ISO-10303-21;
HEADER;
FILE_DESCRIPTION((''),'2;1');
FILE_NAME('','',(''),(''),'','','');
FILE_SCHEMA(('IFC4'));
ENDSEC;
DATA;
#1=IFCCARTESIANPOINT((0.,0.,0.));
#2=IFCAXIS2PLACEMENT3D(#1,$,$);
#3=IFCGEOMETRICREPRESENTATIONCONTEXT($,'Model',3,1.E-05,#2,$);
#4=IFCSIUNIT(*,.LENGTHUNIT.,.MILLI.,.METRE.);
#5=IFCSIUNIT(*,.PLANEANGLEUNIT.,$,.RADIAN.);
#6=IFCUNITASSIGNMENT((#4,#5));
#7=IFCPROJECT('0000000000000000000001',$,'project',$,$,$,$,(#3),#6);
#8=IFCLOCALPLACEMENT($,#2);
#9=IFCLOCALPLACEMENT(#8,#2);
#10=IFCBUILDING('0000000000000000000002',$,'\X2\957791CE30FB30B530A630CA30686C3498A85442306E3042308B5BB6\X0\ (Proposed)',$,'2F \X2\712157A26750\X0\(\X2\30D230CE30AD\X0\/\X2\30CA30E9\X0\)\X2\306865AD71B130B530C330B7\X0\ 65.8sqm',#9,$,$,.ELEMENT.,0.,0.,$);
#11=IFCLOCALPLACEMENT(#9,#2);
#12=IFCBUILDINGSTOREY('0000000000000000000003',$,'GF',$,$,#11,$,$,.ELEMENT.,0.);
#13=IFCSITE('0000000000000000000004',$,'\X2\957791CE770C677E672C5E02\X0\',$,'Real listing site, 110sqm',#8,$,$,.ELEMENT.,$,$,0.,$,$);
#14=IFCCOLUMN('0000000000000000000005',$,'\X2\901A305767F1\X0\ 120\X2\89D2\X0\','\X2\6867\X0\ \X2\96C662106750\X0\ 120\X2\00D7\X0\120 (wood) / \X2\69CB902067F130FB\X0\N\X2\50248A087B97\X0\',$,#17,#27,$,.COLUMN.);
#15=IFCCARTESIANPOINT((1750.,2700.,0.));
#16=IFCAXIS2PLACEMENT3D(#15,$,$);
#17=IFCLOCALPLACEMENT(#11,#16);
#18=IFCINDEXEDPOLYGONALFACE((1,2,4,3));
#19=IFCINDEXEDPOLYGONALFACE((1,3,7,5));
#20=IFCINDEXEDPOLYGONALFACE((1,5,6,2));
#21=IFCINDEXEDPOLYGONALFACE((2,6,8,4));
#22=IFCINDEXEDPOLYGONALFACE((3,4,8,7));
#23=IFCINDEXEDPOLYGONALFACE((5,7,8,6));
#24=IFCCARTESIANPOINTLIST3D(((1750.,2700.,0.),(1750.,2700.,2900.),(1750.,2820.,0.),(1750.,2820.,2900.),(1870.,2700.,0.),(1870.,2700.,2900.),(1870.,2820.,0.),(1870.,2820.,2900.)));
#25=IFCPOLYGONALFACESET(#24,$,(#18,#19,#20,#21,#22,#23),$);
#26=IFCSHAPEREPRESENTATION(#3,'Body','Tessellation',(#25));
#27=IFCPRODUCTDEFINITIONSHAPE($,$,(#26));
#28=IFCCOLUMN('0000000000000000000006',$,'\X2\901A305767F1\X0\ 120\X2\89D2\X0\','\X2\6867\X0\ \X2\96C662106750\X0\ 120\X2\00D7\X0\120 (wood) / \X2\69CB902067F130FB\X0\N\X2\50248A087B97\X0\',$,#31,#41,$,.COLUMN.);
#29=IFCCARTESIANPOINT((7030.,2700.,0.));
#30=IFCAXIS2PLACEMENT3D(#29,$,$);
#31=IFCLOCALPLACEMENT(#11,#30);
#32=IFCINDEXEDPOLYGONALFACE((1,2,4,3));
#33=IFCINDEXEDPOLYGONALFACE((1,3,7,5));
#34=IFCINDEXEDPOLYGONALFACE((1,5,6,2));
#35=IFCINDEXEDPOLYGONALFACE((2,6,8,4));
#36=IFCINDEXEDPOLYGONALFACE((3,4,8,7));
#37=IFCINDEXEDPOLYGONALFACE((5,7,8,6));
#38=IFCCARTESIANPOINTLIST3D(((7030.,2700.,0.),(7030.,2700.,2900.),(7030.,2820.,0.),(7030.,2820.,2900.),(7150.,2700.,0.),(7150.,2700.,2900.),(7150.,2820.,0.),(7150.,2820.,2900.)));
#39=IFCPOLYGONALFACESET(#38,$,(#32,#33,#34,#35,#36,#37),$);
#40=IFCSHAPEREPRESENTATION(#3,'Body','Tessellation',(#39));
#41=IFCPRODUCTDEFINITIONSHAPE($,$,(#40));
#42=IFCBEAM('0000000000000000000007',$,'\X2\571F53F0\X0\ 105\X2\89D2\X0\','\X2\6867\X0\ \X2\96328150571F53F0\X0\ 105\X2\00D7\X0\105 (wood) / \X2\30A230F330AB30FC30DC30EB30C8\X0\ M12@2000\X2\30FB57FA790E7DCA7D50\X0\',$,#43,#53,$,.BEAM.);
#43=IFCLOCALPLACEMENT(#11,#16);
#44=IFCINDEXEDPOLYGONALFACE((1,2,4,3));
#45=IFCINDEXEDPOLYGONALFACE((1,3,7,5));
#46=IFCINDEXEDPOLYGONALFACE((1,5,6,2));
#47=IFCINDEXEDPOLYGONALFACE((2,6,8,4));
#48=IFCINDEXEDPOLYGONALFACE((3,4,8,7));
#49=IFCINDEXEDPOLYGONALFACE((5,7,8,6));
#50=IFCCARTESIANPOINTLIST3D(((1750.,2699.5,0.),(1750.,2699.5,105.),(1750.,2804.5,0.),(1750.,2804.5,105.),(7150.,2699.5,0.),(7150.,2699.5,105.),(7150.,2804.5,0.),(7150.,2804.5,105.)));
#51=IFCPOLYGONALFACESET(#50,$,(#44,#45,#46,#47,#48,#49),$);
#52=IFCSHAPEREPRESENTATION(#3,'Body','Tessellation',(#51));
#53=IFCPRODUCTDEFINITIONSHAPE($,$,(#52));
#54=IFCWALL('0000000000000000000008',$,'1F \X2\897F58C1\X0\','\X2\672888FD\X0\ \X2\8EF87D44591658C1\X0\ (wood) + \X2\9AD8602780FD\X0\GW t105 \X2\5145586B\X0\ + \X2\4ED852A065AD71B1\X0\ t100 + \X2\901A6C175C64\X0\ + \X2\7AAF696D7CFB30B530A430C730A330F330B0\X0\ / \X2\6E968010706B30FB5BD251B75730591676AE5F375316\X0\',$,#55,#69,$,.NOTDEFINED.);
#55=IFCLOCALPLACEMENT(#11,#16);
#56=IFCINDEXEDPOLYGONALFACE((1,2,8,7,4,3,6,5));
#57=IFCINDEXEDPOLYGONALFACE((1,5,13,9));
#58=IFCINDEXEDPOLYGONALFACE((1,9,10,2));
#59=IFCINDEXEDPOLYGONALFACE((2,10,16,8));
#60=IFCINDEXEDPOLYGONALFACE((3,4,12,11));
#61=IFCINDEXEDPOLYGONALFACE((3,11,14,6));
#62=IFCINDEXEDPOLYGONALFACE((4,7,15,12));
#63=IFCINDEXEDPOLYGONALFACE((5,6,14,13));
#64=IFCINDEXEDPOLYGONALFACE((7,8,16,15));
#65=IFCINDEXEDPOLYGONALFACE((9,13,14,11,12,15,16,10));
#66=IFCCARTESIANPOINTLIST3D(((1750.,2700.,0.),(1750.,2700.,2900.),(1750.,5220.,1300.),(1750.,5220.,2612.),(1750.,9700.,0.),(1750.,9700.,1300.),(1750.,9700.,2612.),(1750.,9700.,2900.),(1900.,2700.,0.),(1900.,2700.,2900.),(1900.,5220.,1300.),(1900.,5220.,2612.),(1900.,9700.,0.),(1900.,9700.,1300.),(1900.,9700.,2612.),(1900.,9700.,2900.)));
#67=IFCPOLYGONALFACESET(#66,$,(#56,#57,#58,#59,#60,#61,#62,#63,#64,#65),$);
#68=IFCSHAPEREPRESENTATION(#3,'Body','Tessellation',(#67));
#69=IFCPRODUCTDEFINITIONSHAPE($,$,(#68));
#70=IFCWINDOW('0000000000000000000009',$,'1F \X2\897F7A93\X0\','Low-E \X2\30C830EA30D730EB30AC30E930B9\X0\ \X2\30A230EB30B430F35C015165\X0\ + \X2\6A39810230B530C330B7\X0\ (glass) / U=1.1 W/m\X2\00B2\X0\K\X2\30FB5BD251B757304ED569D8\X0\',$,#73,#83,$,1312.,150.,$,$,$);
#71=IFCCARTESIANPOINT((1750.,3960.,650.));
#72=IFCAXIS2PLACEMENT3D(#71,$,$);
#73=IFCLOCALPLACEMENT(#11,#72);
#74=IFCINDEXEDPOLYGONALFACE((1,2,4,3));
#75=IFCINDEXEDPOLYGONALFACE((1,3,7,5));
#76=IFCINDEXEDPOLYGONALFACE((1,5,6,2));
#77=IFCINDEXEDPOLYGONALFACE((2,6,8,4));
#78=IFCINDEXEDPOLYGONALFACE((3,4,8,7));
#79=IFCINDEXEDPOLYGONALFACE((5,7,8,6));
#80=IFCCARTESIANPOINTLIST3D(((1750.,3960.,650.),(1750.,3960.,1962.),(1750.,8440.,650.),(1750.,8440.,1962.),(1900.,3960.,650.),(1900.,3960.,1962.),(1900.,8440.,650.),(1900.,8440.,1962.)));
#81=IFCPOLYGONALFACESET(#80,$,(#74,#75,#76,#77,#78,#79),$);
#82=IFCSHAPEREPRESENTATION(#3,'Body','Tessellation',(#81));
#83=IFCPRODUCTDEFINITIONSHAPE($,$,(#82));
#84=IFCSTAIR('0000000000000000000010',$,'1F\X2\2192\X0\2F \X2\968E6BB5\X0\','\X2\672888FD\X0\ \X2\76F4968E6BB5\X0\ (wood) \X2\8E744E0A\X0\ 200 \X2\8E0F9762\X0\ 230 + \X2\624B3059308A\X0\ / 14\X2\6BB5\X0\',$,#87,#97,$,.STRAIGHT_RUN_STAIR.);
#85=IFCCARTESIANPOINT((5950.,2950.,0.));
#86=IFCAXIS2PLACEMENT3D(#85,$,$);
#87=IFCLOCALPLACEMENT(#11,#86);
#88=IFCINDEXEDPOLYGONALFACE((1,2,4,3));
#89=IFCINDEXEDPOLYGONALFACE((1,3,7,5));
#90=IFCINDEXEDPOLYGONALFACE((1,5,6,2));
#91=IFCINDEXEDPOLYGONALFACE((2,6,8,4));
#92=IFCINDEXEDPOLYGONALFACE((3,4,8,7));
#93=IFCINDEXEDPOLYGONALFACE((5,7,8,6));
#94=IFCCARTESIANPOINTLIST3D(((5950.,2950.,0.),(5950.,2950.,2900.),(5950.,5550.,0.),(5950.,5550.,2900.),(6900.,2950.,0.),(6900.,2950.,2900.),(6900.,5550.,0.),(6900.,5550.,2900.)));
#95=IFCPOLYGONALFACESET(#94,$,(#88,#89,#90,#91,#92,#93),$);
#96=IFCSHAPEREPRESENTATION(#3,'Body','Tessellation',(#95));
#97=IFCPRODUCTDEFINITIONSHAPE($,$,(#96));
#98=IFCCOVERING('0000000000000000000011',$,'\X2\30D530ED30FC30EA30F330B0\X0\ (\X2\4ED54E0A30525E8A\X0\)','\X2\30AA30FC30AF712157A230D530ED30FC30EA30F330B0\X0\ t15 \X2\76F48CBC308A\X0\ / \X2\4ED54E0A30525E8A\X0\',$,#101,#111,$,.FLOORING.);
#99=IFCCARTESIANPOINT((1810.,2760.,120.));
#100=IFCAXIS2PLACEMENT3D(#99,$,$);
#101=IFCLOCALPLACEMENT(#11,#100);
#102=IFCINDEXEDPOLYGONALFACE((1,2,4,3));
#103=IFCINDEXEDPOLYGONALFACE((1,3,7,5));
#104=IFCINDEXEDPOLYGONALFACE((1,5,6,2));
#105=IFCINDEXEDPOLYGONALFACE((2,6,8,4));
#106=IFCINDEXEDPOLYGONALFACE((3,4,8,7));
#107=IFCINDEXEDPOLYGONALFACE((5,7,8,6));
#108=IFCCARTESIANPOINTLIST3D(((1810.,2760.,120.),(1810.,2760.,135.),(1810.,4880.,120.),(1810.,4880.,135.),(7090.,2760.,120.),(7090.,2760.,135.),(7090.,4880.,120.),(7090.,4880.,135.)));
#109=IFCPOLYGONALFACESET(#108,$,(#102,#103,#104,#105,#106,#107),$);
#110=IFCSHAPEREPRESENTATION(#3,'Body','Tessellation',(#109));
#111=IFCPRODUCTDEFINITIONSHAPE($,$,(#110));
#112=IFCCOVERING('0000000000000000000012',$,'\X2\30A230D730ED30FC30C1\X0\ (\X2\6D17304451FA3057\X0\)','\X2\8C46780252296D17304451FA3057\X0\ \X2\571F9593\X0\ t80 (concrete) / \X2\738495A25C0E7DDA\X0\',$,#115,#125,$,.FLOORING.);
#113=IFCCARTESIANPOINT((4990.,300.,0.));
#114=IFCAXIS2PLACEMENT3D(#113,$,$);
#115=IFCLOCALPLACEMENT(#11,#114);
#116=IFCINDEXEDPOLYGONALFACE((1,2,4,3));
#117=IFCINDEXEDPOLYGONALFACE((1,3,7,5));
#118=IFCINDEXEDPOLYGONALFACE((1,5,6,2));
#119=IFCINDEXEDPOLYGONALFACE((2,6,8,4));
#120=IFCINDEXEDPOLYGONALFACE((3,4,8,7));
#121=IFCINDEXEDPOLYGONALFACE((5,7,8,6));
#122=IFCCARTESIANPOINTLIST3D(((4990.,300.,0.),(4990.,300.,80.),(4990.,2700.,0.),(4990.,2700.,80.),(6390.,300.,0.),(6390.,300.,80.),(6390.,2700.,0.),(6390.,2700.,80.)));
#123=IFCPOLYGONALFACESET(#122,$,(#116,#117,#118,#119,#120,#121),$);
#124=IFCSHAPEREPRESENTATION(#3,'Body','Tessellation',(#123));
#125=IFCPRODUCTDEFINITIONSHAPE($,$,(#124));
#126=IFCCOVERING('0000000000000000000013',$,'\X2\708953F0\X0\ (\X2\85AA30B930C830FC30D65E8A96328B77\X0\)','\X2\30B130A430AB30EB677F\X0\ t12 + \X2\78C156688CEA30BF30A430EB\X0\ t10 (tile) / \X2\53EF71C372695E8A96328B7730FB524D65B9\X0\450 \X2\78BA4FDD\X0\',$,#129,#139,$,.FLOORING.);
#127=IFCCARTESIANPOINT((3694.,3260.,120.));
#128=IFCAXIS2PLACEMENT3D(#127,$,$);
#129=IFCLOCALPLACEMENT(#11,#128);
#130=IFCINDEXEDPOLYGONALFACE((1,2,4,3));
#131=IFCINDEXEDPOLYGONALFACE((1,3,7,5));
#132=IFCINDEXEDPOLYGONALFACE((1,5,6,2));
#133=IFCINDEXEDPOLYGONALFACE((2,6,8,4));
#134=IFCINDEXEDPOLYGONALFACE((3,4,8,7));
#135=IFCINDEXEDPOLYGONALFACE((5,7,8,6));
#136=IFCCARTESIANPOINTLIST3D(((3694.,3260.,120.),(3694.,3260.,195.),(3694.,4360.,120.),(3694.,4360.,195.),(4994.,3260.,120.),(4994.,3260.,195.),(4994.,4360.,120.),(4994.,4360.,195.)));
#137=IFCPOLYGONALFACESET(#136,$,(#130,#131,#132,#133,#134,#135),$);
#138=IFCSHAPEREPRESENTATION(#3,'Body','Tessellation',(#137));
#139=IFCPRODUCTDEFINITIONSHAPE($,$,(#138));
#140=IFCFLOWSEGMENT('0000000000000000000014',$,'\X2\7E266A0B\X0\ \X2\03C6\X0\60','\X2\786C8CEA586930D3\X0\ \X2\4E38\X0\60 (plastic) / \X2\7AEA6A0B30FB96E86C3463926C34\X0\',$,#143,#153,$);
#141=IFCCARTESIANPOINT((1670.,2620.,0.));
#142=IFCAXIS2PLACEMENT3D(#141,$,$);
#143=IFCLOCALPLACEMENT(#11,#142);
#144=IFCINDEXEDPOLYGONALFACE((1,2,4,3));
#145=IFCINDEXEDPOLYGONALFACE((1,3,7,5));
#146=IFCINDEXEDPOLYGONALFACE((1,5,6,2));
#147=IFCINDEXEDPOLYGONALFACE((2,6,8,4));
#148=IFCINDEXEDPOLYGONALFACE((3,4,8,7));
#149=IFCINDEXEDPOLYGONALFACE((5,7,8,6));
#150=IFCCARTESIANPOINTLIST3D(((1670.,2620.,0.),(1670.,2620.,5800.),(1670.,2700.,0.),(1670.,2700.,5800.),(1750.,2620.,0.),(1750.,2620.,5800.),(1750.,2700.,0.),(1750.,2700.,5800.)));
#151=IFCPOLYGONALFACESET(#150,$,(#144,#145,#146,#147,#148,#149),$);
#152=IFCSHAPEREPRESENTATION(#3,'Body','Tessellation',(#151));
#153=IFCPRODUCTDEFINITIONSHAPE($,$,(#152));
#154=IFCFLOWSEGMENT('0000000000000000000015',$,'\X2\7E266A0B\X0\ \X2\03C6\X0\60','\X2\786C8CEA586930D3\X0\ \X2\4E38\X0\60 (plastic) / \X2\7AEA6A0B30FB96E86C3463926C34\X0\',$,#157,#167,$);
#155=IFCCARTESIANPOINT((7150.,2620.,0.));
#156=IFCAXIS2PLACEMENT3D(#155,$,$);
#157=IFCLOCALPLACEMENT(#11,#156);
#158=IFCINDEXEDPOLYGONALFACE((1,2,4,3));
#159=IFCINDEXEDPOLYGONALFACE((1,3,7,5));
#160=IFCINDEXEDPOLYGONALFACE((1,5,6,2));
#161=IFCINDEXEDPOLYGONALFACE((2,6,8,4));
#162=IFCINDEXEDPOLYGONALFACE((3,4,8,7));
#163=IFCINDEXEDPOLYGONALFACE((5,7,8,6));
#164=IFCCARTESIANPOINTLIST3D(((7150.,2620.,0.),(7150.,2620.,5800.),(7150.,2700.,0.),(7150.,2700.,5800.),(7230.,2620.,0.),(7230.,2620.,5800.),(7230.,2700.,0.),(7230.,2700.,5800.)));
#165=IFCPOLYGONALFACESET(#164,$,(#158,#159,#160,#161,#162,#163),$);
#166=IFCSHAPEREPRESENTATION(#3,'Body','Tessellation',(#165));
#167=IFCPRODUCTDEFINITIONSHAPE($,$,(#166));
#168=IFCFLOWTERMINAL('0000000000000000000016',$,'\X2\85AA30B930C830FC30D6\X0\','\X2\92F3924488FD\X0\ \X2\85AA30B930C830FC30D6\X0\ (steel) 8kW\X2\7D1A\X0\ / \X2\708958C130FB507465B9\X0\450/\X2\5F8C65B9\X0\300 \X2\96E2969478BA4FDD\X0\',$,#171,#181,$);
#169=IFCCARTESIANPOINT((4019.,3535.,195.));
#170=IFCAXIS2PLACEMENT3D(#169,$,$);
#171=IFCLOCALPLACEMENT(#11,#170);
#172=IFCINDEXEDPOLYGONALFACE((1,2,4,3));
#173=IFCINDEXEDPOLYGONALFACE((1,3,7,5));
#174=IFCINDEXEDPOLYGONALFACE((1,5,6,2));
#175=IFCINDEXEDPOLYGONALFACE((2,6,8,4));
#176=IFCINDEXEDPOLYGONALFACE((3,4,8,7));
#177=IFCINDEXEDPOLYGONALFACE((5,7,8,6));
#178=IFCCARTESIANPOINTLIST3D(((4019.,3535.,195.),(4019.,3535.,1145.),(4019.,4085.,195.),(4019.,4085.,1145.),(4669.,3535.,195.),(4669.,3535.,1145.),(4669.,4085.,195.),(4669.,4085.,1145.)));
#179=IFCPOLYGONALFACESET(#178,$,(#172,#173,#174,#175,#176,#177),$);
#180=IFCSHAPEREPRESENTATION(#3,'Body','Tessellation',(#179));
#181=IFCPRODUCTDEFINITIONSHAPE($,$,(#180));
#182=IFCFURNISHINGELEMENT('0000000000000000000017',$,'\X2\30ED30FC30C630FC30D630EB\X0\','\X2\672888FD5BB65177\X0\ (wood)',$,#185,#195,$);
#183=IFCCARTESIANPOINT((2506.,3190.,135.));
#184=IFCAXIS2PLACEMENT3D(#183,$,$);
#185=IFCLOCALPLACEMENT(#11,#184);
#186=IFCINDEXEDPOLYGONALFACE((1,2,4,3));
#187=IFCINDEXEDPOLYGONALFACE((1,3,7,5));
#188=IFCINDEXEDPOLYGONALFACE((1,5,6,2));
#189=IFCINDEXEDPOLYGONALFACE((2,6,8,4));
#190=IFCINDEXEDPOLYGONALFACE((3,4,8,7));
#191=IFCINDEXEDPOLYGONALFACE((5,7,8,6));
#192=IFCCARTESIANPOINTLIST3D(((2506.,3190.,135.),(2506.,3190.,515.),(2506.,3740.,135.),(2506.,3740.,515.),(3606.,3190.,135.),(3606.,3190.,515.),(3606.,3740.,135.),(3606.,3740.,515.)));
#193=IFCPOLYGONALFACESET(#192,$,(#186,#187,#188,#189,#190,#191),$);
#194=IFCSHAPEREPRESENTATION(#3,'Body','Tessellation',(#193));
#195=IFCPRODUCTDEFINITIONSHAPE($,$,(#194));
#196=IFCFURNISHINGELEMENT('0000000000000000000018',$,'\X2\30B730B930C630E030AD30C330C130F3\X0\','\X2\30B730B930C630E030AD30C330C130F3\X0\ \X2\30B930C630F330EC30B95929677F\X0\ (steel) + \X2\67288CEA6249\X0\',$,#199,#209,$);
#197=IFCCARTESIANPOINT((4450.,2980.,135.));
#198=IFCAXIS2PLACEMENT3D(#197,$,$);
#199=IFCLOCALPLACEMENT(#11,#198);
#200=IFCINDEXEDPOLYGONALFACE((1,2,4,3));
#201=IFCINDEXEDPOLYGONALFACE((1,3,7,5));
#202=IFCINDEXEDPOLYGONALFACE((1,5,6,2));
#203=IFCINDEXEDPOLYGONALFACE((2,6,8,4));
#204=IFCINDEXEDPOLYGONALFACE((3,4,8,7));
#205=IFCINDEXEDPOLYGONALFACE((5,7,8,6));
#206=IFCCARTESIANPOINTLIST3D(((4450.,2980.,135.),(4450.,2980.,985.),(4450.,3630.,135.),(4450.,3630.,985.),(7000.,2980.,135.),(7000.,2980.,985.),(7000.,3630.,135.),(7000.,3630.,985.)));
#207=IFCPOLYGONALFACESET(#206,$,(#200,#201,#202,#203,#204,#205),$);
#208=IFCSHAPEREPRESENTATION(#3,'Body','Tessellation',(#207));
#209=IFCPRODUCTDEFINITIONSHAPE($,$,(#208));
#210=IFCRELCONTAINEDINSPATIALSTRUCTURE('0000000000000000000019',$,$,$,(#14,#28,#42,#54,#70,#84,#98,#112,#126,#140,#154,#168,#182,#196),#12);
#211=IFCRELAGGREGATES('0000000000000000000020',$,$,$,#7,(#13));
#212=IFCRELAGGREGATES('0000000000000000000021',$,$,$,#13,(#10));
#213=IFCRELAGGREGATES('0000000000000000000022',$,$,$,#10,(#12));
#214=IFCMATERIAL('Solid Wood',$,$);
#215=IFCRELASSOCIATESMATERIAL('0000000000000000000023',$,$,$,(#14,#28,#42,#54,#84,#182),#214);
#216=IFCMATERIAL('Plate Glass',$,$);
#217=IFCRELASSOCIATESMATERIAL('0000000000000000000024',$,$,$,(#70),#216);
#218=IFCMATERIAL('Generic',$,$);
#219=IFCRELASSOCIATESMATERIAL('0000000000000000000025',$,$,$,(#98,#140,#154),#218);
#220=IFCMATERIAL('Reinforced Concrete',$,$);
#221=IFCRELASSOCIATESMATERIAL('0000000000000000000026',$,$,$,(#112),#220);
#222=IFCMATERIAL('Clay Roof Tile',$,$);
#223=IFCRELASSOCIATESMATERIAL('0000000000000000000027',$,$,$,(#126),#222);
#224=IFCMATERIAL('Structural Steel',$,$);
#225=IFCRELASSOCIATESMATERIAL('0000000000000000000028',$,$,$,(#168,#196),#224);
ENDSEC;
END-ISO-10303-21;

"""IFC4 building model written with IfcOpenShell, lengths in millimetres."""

from ifc_helpers import new_model, si_unit, frame, frame_2d, origin, place, context, project, spatial, rectangle, extrude, material, element, fill, save


model = new_model("IFC4")

# Units and contexts
model_context = context("Model", 3, precision=1e-05, world=origin())
ifc_project = project(units=[si_unit("LENGTHUNIT", "METRE", prefix="MILLI"), si_unit("PLANEANGLEUNIT", "RADIAN")], contexts=[model_context])

# Site, building, storey
site_placement = place(None, origin())
site = spatial("IfcSite", under=ifc_project, at=site_placement, Name="長野県松本市", ObjectType="Real listing site, 110sqm", CompositionType="ELEMENT", RefElevation=0.0)
building_placement = place(site_placement, origin())
building = spatial("IfcBuilding", under=site, at=building_placement, Name="長野・サウナと水風呂のある家 (Proposed)", ObjectType="2F 無垢材(ヒノキ/ナラ)と断熱サッシ 65.8sqm", CompositionType="ELEMENT", ElevationOfRefHeight=0.0, ElevationOfTerrain=0.0)
storey_placement = place(building_placement, origin())
storey = spatial("IfcBuildingStorey", under=building, at=storey_placement, Name="GF", CompositionType="ELEMENT", Elevation=0.0)

# Columns
ifc_material_1 = material(Name="Solid Wood")
column_1_placement = place(storey_placement, frame((1750.0, 2700.0, 0.0)))
element("IfcColumn", 1, at=column_1_placement, inside=storey, material=ifc_material_1, Name="通し柱 120角", Description="桧 集成材 120×120 (wood) / 構造柱・N値計算", PredefinedType="COLUMN", context=model_context, shape_type="SweptSolid", body=[
    extrude(rectangle(XDim=120.0, YDim=120.0, at=frame_2d((60.0, 60.0))), frame((1750.0, 2700.0, 0.0)), (0.0, 0.0, 1.0), 2900.0),
])
column_2_placement = place(storey_placement, frame((7030.0, 2700.0, 0.0)))
element("IfcColumn", 2, at=column_2_placement, inside=storey, material=ifc_material_1, Name="通し柱 120角", Description="桧 集成材 120×120 (wood) / 構造柱・N値計算", PredefinedType="COLUMN", context=model_context, shape_type="SweptSolid", body=[
    extrude(rectangle(XDim=120.0, YDim=120.0, at=frame_2d((60.0, 60.0))), frame((7030.0, 2700.0, 0.0)), (0.0, 0.0, 1.0), 2900.0),
])

# Beam
beam_1_placement = place(storey_placement, frame((1750.0, 2700.0, 0.0)))
element("IfcBeam", 3, at=beam_1_placement, inside=storey, material=ifc_material_1, Name="土台 105角", Description="桧 防腐土台 105×105 (wood) / アンカーボルト M12@2000・基礎緊結", PredefinedType="BEAM", context=model_context, shape_type="SweptSolid", body=[
    extrude(rectangle(XDim=5400.0, YDim=105.0, at=frame_2d((2700.0, 52.0))), frame((1750.0, 2700.0, 0.0)), (0.0, 0.0, 1.0), 105.0),
])

# Shared definitions
ifc_material_2 = material(Name="Reinforced Concrete")

# Shared definitions
ifc_material_3 = material(Name="Plate Glass")

# Wall, opening, window
wall_1_placement = place(storey_placement, frame((1750.0, 2700.0, 0.0)))
wall_1 = element("IfcWall", 4, at=wall_1_placement, inside=storey, material=ifc_material_1, Name="1F 西壁", Description="木製 軸組外壁 (wood) + 高性能GW t105 充填 + 付加断熱 t100 + 通気層 + 窯業系サイディング / 準耐火・寒冷地外皮強化", PredefinedType="NOTDEFINED", context=model_context, shape_type="SweptSolid", body=[
    extrude(rectangle(XDim=150.0, YDim=7000.0, at=frame_2d((75.0, 3500.0))), frame((1750.0, 2700.0, 0.0)), (0.0, 0.0, 1.0), 2900.0),
])
opening_1_placement = place(storey_placement, frame((1750.0, 3960.0, 650.0)))
opening_1 = element("IfcOpeningElement", 5, at=opening_1_placement, cuts=wall_1, PredefinedType="NOTDEFINED", context=model_context, shape_type="SweptSolid", body=[
    extrude(rectangle(XDim=150.0, YDim=4480.0, at=frame_2d((75.0, 2240.0))), frame((1750.0, 3960.0, 650.0)), (0.0, 0.0, 1.0), 1312.0),
])
window_1_placement = place(storey_placement, frame((1750.0, 3960.0, 650.0)))
window_1 = element("IfcWindow", 6, at=window_1_placement, inside=storey, material=ifc_material_3, Name="1F 西窓", Description="Low-E トリプルガラス アルゴン封入 + 樹脂サッシ (glass) / U=1.1 W/m²K・寒冷地仕様", OverallHeight=1312.0, OverallWidth=150.0, context=model_context, shape_type="SweptSolid", body=[
    extrude(rectangle(XDim=150.0, YDim=4480.0, at=frame_2d((75.0, 2240.0))), frame((1750.0, 3960.0, 650.0)), (0.0, 0.0, 1.0), 1312.0),
])
fill(opening_1, window_1)

# Stair
stair_placement = place(storey_placement, frame((5950.0, 2950.0, 0.0)))
element("IfcStair", 7, at=stair_placement, inside=storey, material=ifc_material_1, Name="1F→2F 階段", Description="木製 直階段 (wood) 蹴上 200 踏面 230 + 手すり / 14段", PredefinedType="STRAIGHT_RUN_STAIR", context=model_context, shape_type="SweptSolid", body=[
    extrude(rectangle(XDim=950.0, YDim=2600.0, at=frame_2d((475.0, 1300.0))), frame((5950.0, 2950.0, 0.0)), (0.0, 0.0, 1.0), 2900.0),
])

# Coverings
ifc_material_4 = material(Name="Generic")
covering_1_placement = place(storey_placement, frame((1810.0, 2760.0, 120.0)))
element("IfcCovering", 8, at=covering_1_placement, inside=storey, material=ifc_material_4, Name="フローリング (仕上げ床)", Description="オーク無垢フローリング t15 直貼り / 仕上げ床", PredefinedType="FLOORING", context=model_context, shape_type="SweptSolid", body=[
    extrude(rectangle(XDim=5280.0, YDim=2120.0, at=frame_2d((2640.0, 1060.0))), frame((1810.0, 2760.0, 120.0)), (0.0, 0.0, 1.0), 15.0),
])
covering_2_placement = place(storey_placement, frame((4990.0, 300.0, 0.0)))
element("IfcCovering", 9, at=covering_2_placement, inside=storey, material=ifc_material_2, Name="アプローチ (洗い出し)", Description="豆砂利洗い出し 土間 t80 (concrete) / 玄関導線", PredefinedType="FLOORING", context=model_context, shape_type="SweptSolid", body=[
    extrude(rectangle(XDim=1400.0, YDim=2400.0, at=frame_2d((700.0, 1200.0))), frame((4990.0, 300.0, 0.0)), (0.0, 0.0, 1.0), 80.0),
])
ifc_material_5 = material(Name="Clay Roof Tile")
covering_3_placement = place(storey_placement, frame((3694.0, 3260.0, 120.0)))
element("IfcCovering", 10, at=covering_3_placement, inside=storey, material=ifc_material_5, Name="炉台 (薪ストーブ床防護)", Description="ケイカル板 t12 + 磁器質タイル t10 (tile) / 可燃物床防護・前方450 確保", PredefinedType="FLOORING", context=model_context, shape_type="SweptSolid", body=[
    extrude(rectangle(XDim=1300.0, YDim=1100.0, at=frame_2d((650.0, 550.0))), frame((3694.0, 3260.0, 120.0)), (0.0, 0.0, 1.0), 75.0),
])

# Flow segments
flow_segment_1_placement = place(storey_placement, frame((1670.0, 2620.0, 0.0)))
element("IfcFlowSegment", 11, at=flow_segment_1_placement, inside=storey, material=ifc_material_4, Name="縦樋 φ60", Description="硬質塩ビ 丸60 (plastic) / 竪樋・雨水排水", context=model_context, shape_type="SweptSolid", body=[
    extrude(rectangle(XDim=80.0, YDim=80.0, at=frame_2d((40.0, 40.0))), frame((1670.0, 2620.0, 0.0)), (0.0, 0.0, 1.0), 5800.0),
])
flow_segment_2_placement = place(storey_placement, frame((7150.0, 2620.0, 0.0)))
element("IfcFlowSegment", 12, at=flow_segment_2_placement, inside=storey, material=ifc_material_4, Name="縦樋 φ60", Description="硬質塩ビ 丸60 (plastic) / 竪樋・雨水排水", context=model_context, shape_type="SweptSolid", body=[
    extrude(rectangle(XDim=80.0, YDim=80.0, at=frame_2d((40.0, 40.0))), frame((7150.0, 2620.0, 0.0)), (0.0, 0.0, 1.0), 5800.0),
])

# Flow terminal
ifc_material_6 = material(Name="Structural Steel")
flow_terminal_placement = place(storey_placement, frame((4019.0, 3535.0, 195.0)))
element("IfcFlowTerminal", 13, at=flow_terminal_placement, inside=storey, material=ifc_material_6, Name="薪ストーブ", Description="鋳鉄製 薪ストーブ (steel) 8kW級 / 炉壁・側方450/後方300 離隔確保", context=model_context, shape_type="SweptSolid", body=[
    extrude(rectangle(XDim=650.0, YDim=550.0, at=frame_2d((325.0, 275.0))), frame((4019.0, 3535.0, 195.0)), (0.0, 0.0, 1.0), 950.0),
])

# Furnishing elements
furnishing_1_placement = place(storey_placement, frame((2506.0, 3190.0, 135.0)))
element("IfcFurnishingElement", 14, at=furnishing_1_placement, inside=storey, material=ifc_material_1, Name="ローテーブル", Description="木製家具 (wood)", context=model_context, shape_type="SweptSolid", body=[
    extrude(rectangle(XDim=1100.0, YDim=550.0, at=frame_2d((550.0, 275.0))), frame((2506.0, 3190.0, 135.0)), (0.0, 0.0, 1.0), 380.0),
])
furnishing_2_placement = place(storey_placement, frame((4450.0, 2980.0, 135.0)))
element("IfcFurnishingElement", 15, at=furnishing_2_placement, inside=storey, material=ifc_material_6, Name="システムキッチン", Description="システムキッチン ステンレス天板 (steel) + 木質扉", context=model_context, shape_type="SweptSolid", body=[
    extrude(rectangle(XDim=2550.0, YDim=650.0, at=frame_2d((1275.0, 325.0))), frame((4450.0, 2980.0, 135.0)), (0.0, 0.0, 1.0), 850.0),
])

save(model, "model.ifc")
